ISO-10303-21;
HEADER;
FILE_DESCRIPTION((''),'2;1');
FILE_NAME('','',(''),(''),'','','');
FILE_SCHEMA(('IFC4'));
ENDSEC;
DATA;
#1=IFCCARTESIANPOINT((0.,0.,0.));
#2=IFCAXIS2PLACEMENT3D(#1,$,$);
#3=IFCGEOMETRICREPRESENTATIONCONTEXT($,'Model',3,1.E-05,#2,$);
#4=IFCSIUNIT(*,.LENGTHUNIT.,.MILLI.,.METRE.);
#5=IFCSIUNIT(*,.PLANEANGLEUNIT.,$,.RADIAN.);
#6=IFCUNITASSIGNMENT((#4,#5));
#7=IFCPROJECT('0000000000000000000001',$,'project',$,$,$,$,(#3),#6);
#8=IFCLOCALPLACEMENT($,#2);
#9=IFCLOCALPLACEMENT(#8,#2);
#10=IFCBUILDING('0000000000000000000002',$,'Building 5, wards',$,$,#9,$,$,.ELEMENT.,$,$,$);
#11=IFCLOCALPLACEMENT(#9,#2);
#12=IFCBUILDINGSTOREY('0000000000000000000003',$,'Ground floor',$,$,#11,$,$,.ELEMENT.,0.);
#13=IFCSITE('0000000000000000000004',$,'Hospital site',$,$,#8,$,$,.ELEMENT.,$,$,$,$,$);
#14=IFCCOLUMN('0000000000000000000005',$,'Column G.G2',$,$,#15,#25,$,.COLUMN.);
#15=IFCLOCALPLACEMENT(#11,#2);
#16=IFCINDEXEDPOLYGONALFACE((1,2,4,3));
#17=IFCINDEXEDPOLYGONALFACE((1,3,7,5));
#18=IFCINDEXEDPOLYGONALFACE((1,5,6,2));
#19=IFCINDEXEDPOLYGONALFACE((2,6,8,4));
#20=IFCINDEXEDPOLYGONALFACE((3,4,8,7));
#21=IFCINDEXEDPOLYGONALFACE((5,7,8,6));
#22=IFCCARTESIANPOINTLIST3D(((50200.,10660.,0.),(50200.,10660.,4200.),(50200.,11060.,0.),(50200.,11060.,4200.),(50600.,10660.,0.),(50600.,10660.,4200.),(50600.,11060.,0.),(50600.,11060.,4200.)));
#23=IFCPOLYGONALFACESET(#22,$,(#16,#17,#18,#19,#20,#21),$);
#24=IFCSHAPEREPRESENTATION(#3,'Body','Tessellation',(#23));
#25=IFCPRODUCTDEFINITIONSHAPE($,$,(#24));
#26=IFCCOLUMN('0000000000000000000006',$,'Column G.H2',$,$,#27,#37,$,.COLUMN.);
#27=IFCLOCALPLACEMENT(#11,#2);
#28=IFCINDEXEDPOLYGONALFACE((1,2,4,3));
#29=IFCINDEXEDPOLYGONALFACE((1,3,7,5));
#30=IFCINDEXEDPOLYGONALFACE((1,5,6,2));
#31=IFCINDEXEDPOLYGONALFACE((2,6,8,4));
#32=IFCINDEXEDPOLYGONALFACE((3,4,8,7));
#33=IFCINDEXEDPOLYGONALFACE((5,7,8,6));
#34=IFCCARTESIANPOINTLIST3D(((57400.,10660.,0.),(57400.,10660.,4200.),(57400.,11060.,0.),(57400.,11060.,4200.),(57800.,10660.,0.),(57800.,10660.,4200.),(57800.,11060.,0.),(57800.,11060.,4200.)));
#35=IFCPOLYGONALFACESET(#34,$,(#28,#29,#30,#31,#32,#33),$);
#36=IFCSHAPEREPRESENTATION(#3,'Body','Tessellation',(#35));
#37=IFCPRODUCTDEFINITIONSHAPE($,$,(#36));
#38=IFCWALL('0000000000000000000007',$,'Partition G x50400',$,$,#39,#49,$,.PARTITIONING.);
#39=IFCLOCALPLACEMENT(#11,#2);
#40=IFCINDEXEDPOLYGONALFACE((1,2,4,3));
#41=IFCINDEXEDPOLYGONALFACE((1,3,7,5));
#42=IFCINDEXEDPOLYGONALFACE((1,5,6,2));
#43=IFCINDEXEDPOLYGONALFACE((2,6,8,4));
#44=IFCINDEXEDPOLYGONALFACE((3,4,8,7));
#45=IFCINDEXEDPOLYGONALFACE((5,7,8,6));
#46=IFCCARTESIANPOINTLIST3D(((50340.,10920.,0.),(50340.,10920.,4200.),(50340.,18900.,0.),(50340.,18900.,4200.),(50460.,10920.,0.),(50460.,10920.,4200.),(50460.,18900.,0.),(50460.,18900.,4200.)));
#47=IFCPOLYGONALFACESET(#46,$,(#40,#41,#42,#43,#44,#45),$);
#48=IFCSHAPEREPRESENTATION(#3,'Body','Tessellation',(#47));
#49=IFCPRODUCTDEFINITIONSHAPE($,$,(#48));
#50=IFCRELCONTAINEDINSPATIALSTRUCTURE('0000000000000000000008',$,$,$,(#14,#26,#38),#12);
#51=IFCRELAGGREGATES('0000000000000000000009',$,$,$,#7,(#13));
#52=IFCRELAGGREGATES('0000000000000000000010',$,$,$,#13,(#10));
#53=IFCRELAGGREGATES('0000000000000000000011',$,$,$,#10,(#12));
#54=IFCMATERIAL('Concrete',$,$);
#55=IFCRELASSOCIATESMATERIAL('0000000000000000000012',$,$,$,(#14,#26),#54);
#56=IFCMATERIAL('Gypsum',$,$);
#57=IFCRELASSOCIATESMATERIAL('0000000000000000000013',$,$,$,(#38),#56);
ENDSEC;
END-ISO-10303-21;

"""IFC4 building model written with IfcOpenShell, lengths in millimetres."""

from ifc_helpers import new_model, si_unit, frame, frame_2d, origin, origin_2d, place, context, project, spatial, rectangle, extrude, material, element, save


model = new_model("IFC4")

# Units and contexts
model_context = context("Model", 3, precision=1e-05, world=origin())
ifc_project = project(units=[si_unit("LENGTHUNIT", "METRE", prefix="MILLI"), si_unit("PLANEANGLEUNIT", "RADIAN")], contexts=[model_context])

# Site, building, storey
site_placement = place(None, origin())
site = spatial("IfcSite", under=ifc_project, at=site_placement, Name="Hospital site", CompositionType="ELEMENT")
building_placement = place(site_placement, origin())
building = spatial("IfcBuilding", under=site, at=building_placement, Name="Building 5, wards", CompositionType="ELEMENT")
storey_placement = place(building_placement, origin())
storey = spatial("IfcBuildingStorey", under=building, at=storey_placement, Name="Ground floor", CompositionType="ELEMENT", Elevation=0.0)

# Columns
ifc_material_1 = material(Name="Concrete")
for number, where, name in (
    (1, (50400.0, 10860.0, 0.0), "Column G.G2"),
    (2, (57600.0, 10860.0, 0.0), "Column G.H2"),
):
    element("IfcColumn", number, at=place(storey_placement, frame(where)), inside=storey, material=ifc_material_1, Name=name, PredefinedType="COLUMN", context=model_context, shape_type="SweptSolid", body=[
        extrude(rectangle(XDim=400.0, YDim=400.0, at=origin_2d()), origin(), (0.0, 0.0, 1.0), 4200.0),
    ])

# Wall
ifc_material_2 = material(Name="Gypsum")
wall_placement = place(storey_placement, frame((50460.0, 10920.0, 0.0), x_axis=(0.0, 1.0, 0.0)))
element("IfcWall", 3, at=wall_placement, inside=storey, material=ifc_material_2, Name="Partition G x50400", PredefinedType="PARTITIONING", context=model_context, shape_type="SweptSolid", body=[
    extrude(rectangle(XDim=7980.0, YDim=120.0, at=frame_2d((3990.0, 60.0))), origin(), (0.0, 0.0, 1.0), 4200.0),
])

save(model, "model.ifc")
